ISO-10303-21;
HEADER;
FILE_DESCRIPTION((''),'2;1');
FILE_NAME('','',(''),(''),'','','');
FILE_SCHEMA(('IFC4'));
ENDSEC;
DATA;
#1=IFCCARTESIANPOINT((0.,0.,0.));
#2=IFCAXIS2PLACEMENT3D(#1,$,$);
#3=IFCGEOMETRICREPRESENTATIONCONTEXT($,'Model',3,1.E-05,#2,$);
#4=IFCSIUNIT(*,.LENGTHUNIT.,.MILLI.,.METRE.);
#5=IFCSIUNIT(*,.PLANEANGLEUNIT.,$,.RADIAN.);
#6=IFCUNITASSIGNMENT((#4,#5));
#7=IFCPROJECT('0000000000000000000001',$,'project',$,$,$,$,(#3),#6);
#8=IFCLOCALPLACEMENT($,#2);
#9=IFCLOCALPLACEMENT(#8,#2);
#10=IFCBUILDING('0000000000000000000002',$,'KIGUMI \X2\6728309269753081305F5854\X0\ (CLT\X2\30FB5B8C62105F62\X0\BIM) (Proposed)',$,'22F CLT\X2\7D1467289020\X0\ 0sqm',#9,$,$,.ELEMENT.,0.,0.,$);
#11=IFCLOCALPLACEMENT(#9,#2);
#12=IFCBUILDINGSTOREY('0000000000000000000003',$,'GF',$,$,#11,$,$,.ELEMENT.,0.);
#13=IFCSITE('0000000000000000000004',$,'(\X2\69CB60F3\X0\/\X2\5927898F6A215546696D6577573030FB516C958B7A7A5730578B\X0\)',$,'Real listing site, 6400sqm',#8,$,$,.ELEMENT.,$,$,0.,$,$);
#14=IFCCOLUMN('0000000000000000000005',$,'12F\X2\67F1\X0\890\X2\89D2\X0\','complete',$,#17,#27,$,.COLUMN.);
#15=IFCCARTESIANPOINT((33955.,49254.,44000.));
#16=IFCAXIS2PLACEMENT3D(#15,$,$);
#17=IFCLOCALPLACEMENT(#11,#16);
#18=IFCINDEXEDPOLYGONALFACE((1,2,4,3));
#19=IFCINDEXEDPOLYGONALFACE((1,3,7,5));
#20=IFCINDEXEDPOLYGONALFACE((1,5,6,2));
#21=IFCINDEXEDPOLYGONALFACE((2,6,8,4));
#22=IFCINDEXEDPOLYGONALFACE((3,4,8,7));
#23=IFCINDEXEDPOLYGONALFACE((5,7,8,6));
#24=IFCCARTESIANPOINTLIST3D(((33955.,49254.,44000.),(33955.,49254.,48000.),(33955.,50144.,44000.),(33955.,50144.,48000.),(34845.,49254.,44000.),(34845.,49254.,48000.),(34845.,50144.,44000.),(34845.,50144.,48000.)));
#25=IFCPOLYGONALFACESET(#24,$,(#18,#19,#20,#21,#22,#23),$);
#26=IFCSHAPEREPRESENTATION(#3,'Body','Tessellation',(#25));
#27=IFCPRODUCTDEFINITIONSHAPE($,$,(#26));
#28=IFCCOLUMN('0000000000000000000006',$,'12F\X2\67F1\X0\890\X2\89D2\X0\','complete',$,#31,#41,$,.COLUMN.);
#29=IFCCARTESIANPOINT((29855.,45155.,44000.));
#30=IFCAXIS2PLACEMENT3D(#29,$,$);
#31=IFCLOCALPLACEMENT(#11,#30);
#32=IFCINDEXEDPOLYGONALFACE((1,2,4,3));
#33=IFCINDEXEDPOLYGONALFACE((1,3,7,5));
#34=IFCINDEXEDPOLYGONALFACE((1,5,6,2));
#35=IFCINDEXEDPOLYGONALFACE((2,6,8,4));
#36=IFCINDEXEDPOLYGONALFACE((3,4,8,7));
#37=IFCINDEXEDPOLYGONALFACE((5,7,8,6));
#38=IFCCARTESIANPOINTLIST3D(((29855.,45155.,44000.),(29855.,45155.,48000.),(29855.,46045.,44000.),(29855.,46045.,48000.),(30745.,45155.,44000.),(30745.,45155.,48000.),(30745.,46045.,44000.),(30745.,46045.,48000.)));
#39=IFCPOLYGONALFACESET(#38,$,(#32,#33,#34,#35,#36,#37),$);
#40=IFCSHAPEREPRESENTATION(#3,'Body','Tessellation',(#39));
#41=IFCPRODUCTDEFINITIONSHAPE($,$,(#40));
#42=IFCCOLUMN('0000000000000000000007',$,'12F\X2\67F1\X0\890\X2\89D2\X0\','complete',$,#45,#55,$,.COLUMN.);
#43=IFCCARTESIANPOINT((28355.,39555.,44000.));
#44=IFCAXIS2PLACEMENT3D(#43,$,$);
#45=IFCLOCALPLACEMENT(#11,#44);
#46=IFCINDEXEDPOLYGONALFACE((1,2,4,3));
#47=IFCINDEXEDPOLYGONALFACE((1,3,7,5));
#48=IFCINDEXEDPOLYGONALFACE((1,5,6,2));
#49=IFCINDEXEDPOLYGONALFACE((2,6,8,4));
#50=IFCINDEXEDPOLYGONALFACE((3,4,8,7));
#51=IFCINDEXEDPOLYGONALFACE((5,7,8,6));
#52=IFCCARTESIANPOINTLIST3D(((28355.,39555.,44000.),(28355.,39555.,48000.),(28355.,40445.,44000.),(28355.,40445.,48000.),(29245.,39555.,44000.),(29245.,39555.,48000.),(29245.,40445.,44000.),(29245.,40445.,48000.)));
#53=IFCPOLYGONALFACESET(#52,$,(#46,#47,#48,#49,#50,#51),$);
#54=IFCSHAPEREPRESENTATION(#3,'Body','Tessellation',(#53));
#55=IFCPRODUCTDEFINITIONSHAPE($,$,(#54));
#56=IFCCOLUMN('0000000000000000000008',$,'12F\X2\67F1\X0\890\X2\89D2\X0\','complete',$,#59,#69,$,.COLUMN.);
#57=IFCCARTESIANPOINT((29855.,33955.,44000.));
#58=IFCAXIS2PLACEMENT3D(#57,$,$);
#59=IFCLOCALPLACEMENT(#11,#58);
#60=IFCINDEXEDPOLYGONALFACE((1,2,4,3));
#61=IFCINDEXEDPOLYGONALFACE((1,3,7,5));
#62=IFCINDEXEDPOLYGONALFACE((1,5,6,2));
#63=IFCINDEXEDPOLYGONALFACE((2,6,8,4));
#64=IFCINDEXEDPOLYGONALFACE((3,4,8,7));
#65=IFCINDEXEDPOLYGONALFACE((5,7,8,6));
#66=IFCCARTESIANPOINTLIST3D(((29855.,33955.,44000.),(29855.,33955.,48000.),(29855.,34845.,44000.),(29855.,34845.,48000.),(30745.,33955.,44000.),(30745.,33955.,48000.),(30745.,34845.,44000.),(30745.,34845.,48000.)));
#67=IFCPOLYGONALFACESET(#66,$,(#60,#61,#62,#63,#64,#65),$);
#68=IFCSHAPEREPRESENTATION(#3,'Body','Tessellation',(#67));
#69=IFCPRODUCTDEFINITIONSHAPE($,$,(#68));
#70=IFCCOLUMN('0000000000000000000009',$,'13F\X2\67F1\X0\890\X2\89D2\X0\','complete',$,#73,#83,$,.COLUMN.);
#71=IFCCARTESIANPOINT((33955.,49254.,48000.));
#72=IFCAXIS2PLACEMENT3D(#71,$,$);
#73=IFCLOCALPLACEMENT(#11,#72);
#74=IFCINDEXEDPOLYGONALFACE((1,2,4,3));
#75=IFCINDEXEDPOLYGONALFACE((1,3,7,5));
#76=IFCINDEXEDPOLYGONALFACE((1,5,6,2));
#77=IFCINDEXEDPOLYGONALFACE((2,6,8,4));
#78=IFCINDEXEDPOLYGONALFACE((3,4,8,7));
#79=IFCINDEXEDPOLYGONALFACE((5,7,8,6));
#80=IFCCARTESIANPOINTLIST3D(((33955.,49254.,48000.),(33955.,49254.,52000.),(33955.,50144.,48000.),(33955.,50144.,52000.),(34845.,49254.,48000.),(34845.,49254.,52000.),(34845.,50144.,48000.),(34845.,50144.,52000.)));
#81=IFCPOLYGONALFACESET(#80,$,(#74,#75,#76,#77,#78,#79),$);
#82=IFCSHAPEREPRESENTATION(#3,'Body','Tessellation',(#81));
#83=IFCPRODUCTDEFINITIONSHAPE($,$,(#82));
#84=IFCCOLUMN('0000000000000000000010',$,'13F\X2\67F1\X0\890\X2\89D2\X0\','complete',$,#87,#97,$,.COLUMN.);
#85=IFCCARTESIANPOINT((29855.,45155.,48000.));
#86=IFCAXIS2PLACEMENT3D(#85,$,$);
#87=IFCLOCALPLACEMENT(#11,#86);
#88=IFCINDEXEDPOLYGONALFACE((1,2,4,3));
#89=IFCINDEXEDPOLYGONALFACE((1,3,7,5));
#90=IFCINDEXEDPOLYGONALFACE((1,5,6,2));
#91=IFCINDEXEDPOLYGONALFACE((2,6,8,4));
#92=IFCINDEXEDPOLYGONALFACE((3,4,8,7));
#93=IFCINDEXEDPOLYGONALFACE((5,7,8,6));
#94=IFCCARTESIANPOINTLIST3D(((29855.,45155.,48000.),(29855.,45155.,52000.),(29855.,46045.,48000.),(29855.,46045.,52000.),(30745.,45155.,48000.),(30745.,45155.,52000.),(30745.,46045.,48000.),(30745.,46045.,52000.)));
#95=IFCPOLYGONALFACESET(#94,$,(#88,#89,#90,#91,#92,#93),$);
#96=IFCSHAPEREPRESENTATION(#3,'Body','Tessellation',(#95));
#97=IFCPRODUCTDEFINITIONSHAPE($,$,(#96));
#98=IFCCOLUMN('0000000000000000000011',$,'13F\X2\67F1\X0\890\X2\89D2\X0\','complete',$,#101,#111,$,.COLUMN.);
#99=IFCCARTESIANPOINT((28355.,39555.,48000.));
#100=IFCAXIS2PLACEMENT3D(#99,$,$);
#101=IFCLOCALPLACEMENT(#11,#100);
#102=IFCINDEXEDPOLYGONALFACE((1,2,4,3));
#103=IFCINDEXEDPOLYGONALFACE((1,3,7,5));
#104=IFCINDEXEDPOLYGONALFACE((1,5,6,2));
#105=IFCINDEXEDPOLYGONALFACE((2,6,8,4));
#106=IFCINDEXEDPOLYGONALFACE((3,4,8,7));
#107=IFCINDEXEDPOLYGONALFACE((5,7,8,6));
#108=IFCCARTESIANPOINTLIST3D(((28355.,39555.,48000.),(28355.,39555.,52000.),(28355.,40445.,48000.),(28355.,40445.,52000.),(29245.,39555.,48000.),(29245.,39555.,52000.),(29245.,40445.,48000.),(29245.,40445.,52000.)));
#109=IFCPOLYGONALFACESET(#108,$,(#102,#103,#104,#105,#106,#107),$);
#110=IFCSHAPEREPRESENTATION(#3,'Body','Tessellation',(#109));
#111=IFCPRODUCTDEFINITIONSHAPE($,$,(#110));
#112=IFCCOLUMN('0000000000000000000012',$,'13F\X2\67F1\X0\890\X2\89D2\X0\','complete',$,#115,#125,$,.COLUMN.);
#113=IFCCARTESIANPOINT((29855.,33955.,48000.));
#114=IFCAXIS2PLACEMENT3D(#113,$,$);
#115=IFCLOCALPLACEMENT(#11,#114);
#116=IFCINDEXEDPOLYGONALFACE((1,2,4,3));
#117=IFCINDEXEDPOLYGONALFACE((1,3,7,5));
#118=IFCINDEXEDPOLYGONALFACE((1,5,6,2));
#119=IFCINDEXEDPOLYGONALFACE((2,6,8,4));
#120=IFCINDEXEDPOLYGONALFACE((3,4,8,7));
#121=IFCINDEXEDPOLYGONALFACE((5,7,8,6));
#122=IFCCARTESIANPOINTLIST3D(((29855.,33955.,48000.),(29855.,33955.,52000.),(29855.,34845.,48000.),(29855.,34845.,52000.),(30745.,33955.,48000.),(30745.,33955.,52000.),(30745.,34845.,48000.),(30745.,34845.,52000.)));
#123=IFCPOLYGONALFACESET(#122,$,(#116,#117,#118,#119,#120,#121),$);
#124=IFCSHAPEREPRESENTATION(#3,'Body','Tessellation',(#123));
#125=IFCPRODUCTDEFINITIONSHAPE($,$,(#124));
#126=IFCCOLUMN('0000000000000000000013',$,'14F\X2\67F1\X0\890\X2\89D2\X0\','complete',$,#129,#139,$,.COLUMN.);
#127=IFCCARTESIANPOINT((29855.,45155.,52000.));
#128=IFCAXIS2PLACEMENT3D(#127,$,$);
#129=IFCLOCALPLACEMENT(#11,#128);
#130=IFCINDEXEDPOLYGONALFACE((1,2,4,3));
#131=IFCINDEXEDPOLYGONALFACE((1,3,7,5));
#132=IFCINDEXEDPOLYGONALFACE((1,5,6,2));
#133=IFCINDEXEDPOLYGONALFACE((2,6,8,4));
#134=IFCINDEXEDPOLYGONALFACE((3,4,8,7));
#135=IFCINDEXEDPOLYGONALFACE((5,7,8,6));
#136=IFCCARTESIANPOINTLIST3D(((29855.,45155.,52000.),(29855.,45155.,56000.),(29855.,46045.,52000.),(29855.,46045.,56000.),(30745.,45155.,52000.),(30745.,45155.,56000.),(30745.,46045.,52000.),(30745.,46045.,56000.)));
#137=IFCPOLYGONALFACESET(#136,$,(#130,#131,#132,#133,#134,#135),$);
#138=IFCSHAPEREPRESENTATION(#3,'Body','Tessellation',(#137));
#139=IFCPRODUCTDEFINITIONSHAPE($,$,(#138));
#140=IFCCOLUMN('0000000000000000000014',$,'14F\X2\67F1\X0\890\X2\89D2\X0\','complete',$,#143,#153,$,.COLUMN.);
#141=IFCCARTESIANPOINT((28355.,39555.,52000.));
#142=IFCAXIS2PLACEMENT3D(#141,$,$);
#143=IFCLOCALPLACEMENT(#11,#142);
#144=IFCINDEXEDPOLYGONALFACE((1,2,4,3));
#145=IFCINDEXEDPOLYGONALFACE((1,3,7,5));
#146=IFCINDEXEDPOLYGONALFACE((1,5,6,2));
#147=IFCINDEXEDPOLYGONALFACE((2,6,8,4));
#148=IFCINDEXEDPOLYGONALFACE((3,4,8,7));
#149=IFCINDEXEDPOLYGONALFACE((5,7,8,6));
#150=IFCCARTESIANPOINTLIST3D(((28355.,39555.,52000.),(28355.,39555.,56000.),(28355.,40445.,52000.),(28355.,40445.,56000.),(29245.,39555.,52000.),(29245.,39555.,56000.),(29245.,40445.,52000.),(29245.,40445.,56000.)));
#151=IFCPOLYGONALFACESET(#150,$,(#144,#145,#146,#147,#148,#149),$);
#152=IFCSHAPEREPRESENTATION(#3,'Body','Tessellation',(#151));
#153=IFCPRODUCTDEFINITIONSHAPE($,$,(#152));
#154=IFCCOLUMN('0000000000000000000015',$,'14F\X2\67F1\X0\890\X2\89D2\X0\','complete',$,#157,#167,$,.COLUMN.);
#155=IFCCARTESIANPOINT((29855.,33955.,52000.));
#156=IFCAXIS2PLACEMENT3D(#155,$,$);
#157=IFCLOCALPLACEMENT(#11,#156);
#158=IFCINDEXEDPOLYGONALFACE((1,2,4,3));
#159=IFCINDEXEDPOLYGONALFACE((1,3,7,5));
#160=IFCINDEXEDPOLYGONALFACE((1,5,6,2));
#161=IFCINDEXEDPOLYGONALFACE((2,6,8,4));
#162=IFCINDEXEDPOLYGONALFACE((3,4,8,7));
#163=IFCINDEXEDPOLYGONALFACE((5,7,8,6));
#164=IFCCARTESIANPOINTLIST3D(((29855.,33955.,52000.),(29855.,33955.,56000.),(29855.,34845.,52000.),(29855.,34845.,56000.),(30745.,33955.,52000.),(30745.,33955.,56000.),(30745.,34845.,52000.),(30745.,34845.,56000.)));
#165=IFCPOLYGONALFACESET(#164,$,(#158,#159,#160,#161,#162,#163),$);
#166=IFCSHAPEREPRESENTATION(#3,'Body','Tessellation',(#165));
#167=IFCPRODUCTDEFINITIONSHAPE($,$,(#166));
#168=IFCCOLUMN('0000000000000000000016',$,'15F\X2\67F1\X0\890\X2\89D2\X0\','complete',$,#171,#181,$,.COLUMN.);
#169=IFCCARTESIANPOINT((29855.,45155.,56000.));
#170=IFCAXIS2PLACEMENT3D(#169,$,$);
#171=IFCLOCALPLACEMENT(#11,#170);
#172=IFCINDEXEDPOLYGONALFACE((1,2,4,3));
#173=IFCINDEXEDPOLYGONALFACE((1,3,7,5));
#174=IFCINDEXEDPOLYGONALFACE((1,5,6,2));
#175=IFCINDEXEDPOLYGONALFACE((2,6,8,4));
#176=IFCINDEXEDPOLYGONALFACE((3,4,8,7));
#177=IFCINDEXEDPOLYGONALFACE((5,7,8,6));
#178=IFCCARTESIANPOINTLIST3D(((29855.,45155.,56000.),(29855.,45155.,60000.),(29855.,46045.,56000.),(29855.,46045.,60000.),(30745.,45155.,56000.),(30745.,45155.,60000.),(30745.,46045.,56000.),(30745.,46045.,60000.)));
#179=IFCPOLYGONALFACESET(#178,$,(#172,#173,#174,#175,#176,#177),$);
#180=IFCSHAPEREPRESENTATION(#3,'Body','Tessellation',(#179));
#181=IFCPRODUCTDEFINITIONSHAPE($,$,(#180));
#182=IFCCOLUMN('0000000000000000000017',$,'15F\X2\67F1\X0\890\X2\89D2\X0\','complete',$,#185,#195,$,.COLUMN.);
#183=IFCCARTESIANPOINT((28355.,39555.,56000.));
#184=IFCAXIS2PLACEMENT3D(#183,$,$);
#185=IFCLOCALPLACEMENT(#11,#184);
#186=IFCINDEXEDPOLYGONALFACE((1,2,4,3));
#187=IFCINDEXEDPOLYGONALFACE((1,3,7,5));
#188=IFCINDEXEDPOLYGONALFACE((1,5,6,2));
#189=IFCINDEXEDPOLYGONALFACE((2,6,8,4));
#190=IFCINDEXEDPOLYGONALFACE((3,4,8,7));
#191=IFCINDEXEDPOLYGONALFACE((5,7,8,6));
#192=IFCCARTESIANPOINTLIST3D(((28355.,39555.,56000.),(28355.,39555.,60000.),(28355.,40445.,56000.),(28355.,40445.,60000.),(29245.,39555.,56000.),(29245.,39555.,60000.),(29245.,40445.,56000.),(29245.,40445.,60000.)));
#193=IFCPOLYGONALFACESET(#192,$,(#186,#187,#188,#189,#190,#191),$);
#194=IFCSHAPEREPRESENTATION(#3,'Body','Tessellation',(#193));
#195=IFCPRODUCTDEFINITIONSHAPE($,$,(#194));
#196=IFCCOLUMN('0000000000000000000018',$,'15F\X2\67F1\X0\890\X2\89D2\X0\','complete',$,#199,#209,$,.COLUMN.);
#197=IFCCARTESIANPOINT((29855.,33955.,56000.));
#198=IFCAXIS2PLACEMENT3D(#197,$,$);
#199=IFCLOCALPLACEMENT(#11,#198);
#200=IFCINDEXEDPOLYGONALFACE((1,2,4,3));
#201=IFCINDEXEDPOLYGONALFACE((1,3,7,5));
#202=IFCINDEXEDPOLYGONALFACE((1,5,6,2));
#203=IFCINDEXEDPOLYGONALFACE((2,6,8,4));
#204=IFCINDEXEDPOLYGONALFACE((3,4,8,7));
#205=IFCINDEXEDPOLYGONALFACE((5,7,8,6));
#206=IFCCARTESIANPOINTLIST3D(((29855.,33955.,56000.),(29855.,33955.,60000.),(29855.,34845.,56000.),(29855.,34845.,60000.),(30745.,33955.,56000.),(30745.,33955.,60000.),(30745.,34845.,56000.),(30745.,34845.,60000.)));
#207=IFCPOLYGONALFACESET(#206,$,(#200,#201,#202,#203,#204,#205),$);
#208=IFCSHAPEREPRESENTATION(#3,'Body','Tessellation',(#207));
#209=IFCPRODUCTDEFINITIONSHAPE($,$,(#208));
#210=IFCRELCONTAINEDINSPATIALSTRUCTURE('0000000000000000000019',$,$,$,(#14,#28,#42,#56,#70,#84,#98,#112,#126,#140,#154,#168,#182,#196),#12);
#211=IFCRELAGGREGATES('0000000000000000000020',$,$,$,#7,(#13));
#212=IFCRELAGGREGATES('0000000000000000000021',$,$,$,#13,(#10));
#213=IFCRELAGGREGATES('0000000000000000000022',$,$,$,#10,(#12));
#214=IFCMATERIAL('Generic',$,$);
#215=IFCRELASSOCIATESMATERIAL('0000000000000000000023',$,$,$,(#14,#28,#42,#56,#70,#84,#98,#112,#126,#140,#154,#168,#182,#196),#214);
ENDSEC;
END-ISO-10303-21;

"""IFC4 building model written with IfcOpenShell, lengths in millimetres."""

from ifc_helpers import new_model, si_unit, frame, frame_2d, origin, place, context, project, spatial, rectangle, extrude, material, element, save


model = new_model("IFC4")

# Units and contexts
model_context = context("Model", 3, precision=1e-05, world=origin())
ifc_project = project(units=[si_unit("LENGTHUNIT", "METRE", prefix="MILLI"), si_unit("PLANEANGLEUNIT", "RADIAN")], contexts=[model_context])

# Site, building, storey
site_placement = place(None, origin())
site = spatial("IfcSite", under=ifc_project, at=site_placement, Name="(構想/大規模商業敷地・公開空地型)", ObjectType="Real listing site, 6400sqm", CompositionType="ELEMENT", RefElevation=0.0)
building_placement = place(site_placement, origin())
building = spatial("IfcBuilding", under=site, at=building_placement, Name="KIGUMI 木を極めた塔 (CLT・完成形BIM) (Proposed)", ObjectType="22F CLT純木造 0sqm", CompositionType="ELEMENT", ElevationOfRefHeight=0.0, ElevationOfTerrain=0.0)
storey_placement = place(building_placement, origin())
storey = spatial("IfcBuildingStorey", under=building, at=storey_placement, Name="GF", CompositionType="ELEMENT", Elevation=0.0)

# Columns
ifc_material = material(Name="Generic")
column_1_placement = place(storey_placement, frame((33955.0, 49254.0, 44000.0)))
element("IfcColumn", 1, at=column_1_placement, inside=storey, material=ifc_material, Name="12F柱890角", Description="complete", PredefinedType="COLUMN", context=model_context, shape_type="SweptSolid", body=[
    extrude(rectangle(XDim=890.0, YDim=890.0, at=frame_2d((445.0, 445.0))), frame((33955.0, 49254.0, 44000.0)), (0.0, 0.0, 1.0), 4000.0),
])
column_2_placement = place(storey_placement, frame((29855.0, 45155.0, 44000.0)))
element("IfcColumn", 2, at=column_2_placement, inside=storey, material=ifc_material, Name="12F柱890角", Description="complete", PredefinedType="COLUMN", context=model_context, shape_type="SweptSolid", body=[
    extrude(rectangle(XDim=890.0, YDim=890.0, at=frame_2d((445.0, 445.0))), frame((29855.0, 45155.0, 44000.0)), (0.0, 0.0, 1.0), 4000.0),
])
column_3_placement = place(storey_placement, frame((28355.0, 39555.0, 44000.0)))
element("IfcColumn", 3, at=column_3_placement, inside=storey, material=ifc_material, Name="12F柱890角", Description="complete", PredefinedType="COLUMN", context=model_context, shape_type="SweptSolid", body=[
    extrude(rectangle(XDim=890.0, YDim=890.0, at=frame_2d((445.0, 445.0))), frame((28355.0, 39555.0, 44000.0)), (0.0, 0.0, 1.0), 4000.0),
])
column_4_placement = place(storey_placement, frame((29855.0, 33955.0, 44000.0)))
element("IfcColumn", 4, at=column_4_placement, inside=storey, material=ifc_material, Name="12F柱890角", Description="complete", PredefinedType="COLUMN", context=model_context, shape_type="SweptSolid", body=[
    extrude(rectangle(XDim=890.0, YDim=890.0, at=frame_2d((445.0, 445.0))), frame((29855.0, 33955.0, 44000.0)), (0.0, 0.0, 1.0), 4000.0),
])
column_5_placement = place(storey_placement, frame((33955.0, 49254.0, 48000.0)))
element("IfcColumn", 5, at=column_5_placement, inside=storey, material=ifc_material, Name="13F柱890角", Description="complete", PredefinedType="COLUMN", context=model_context, shape_type="SweptSolid", body=[
    extrude(rectangle(XDim=890.0, YDim=890.0, at=frame_2d((445.0, 445.0))), frame((33955.0, 49254.0, 48000.0)), (0.0, 0.0, 1.0), 4000.0),
])
column_6_placement = place(storey_placement, frame((29855.0, 45155.0, 48000.0)))
element("IfcColumn", 6, at=column_6_placement, inside=storey, material=ifc_material, Name="13F柱890角", Description="complete", PredefinedType="COLUMN", context=model_context, shape_type="SweptSolid", body=[
    extrude(rectangle(XDim=890.0, YDim=890.0, at=frame_2d((445.0, 445.0))), frame((29855.0, 45155.0, 48000.0)), (0.0, 0.0, 1.0), 4000.0),
])
column_7_placement = place(storey_placement, frame((28355.0, 39555.0, 48000.0)))
element("IfcColumn", 7, at=column_7_placement, inside=storey, material=ifc_material, Name="13F柱890角", Description="complete", PredefinedType="COLUMN", context=model_context, shape_type="SweptSolid", body=[
    extrude(rectangle(XDim=890.0, YDim=890.0, at=frame_2d((445.0, 445.0))), frame((28355.0, 39555.0, 48000.0)), (0.0, 0.0, 1.0), 4000.0),
])
column_8_placement = place(storey_placement, frame((29855.0, 33955.0, 48000.0)))
element("IfcColumn", 8, at=column_8_placement, inside=storey, material=ifc_material, Name="13F柱890角", Description="complete", PredefinedType="COLUMN", context=model_context, shape_type="SweptSolid", body=[
    extrude(rectangle(XDim=890.0, YDim=890.0, at=frame_2d((445.0, 445.0))), frame((29855.0, 33955.0, 48000.0)), (0.0, 0.0, 1.0), 4000.0),
])
column_9_placement = place(storey_placement, frame((29855.0, 45155.0, 52000.0)))
element("IfcColumn", 9, at=column_9_placement, inside=storey, material=ifc_material, Name="14F柱890角", Description="complete", PredefinedType="COLUMN", context=model_context, shape_type="SweptSolid", body=[
    extrude(rectangle(XDim=890.0, YDim=890.0, at=frame_2d((445.0, 445.0))), frame((29855.0, 45155.0, 52000.0)), (0.0, 0.0, 1.0), 4000.0),
])
column_10_placement = place(storey_placement, frame((28355.0, 39555.0, 52000.0)))
element("IfcColumn", 10, at=column_10_placement, inside=storey, material=ifc_material, Name="14F柱890角", Description="complete", PredefinedType="COLUMN", context=model_context, shape_type="SweptSolid", body=[
    extrude(rectangle(XDim=890.0, YDim=890.0, at=frame_2d((445.0, 445.0))), frame((28355.0, 39555.0, 52000.0)), (0.0, 0.0, 1.0), 4000.0),
])
column_11_placement = place(storey_placement, frame((29855.0, 33955.0, 52000.0)))
element("IfcColumn", 11, at=column_11_placement, inside=storey, material=ifc_material, Name="14F柱890角", Description="complete", PredefinedType="COLUMN", context=model_context, shape_type="SweptSolid", body=[
    extrude(rectangle(XDim=890.0, YDim=890.0, at=frame_2d((445.0, 445.0))), frame((29855.0, 33955.0, 52000.0)), (0.0, 0.0, 1.0), 4000.0),
])
column_12_placement = place(storey_placement, frame((29855.0, 45155.0, 56000.0)))
element("IfcColumn", 12, at=column_12_placement, inside=storey, material=ifc_material, Name="15F柱890角", Description="complete", PredefinedType="COLUMN", context=model_context, shape_type="SweptSolid", body=[
    extrude(rectangle(XDim=890.0, YDim=890.0, at=frame_2d((445.0, 445.0))), frame((29855.0, 45155.0, 56000.0)), (0.0, 0.0, 1.0), 4000.0),
])
column_13_placement = place(storey_placement, frame((28355.0, 39555.0, 56000.0)))
element("IfcColumn", 13, at=column_13_placement, inside=storey, material=ifc_material, Name="15F柱890角", Description="complete", PredefinedType="COLUMN", context=model_context, shape_type="SweptSolid", body=[
    extrude(rectangle(XDim=890.0, YDim=890.0, at=frame_2d((445.0, 445.0))), frame((28355.0, 39555.0, 56000.0)), (0.0, 0.0, 1.0), 4000.0),
])
column_14_placement = place(storey_placement, frame((29855.0, 33955.0, 56000.0)))
element("IfcColumn", 14, at=column_14_placement, inside=storey, material=ifc_material, Name="15F柱890角", Description="complete", PredefinedType="COLUMN", context=model_context, shape_type="SweptSolid", body=[
    extrude(rectangle(XDim=890.0, YDim=890.0, at=frame_2d((445.0, 445.0))), frame((29855.0, 33955.0, 56000.0)), (0.0, 0.0, 1.0), 4000.0),
])

save(model, "model.ifc")
